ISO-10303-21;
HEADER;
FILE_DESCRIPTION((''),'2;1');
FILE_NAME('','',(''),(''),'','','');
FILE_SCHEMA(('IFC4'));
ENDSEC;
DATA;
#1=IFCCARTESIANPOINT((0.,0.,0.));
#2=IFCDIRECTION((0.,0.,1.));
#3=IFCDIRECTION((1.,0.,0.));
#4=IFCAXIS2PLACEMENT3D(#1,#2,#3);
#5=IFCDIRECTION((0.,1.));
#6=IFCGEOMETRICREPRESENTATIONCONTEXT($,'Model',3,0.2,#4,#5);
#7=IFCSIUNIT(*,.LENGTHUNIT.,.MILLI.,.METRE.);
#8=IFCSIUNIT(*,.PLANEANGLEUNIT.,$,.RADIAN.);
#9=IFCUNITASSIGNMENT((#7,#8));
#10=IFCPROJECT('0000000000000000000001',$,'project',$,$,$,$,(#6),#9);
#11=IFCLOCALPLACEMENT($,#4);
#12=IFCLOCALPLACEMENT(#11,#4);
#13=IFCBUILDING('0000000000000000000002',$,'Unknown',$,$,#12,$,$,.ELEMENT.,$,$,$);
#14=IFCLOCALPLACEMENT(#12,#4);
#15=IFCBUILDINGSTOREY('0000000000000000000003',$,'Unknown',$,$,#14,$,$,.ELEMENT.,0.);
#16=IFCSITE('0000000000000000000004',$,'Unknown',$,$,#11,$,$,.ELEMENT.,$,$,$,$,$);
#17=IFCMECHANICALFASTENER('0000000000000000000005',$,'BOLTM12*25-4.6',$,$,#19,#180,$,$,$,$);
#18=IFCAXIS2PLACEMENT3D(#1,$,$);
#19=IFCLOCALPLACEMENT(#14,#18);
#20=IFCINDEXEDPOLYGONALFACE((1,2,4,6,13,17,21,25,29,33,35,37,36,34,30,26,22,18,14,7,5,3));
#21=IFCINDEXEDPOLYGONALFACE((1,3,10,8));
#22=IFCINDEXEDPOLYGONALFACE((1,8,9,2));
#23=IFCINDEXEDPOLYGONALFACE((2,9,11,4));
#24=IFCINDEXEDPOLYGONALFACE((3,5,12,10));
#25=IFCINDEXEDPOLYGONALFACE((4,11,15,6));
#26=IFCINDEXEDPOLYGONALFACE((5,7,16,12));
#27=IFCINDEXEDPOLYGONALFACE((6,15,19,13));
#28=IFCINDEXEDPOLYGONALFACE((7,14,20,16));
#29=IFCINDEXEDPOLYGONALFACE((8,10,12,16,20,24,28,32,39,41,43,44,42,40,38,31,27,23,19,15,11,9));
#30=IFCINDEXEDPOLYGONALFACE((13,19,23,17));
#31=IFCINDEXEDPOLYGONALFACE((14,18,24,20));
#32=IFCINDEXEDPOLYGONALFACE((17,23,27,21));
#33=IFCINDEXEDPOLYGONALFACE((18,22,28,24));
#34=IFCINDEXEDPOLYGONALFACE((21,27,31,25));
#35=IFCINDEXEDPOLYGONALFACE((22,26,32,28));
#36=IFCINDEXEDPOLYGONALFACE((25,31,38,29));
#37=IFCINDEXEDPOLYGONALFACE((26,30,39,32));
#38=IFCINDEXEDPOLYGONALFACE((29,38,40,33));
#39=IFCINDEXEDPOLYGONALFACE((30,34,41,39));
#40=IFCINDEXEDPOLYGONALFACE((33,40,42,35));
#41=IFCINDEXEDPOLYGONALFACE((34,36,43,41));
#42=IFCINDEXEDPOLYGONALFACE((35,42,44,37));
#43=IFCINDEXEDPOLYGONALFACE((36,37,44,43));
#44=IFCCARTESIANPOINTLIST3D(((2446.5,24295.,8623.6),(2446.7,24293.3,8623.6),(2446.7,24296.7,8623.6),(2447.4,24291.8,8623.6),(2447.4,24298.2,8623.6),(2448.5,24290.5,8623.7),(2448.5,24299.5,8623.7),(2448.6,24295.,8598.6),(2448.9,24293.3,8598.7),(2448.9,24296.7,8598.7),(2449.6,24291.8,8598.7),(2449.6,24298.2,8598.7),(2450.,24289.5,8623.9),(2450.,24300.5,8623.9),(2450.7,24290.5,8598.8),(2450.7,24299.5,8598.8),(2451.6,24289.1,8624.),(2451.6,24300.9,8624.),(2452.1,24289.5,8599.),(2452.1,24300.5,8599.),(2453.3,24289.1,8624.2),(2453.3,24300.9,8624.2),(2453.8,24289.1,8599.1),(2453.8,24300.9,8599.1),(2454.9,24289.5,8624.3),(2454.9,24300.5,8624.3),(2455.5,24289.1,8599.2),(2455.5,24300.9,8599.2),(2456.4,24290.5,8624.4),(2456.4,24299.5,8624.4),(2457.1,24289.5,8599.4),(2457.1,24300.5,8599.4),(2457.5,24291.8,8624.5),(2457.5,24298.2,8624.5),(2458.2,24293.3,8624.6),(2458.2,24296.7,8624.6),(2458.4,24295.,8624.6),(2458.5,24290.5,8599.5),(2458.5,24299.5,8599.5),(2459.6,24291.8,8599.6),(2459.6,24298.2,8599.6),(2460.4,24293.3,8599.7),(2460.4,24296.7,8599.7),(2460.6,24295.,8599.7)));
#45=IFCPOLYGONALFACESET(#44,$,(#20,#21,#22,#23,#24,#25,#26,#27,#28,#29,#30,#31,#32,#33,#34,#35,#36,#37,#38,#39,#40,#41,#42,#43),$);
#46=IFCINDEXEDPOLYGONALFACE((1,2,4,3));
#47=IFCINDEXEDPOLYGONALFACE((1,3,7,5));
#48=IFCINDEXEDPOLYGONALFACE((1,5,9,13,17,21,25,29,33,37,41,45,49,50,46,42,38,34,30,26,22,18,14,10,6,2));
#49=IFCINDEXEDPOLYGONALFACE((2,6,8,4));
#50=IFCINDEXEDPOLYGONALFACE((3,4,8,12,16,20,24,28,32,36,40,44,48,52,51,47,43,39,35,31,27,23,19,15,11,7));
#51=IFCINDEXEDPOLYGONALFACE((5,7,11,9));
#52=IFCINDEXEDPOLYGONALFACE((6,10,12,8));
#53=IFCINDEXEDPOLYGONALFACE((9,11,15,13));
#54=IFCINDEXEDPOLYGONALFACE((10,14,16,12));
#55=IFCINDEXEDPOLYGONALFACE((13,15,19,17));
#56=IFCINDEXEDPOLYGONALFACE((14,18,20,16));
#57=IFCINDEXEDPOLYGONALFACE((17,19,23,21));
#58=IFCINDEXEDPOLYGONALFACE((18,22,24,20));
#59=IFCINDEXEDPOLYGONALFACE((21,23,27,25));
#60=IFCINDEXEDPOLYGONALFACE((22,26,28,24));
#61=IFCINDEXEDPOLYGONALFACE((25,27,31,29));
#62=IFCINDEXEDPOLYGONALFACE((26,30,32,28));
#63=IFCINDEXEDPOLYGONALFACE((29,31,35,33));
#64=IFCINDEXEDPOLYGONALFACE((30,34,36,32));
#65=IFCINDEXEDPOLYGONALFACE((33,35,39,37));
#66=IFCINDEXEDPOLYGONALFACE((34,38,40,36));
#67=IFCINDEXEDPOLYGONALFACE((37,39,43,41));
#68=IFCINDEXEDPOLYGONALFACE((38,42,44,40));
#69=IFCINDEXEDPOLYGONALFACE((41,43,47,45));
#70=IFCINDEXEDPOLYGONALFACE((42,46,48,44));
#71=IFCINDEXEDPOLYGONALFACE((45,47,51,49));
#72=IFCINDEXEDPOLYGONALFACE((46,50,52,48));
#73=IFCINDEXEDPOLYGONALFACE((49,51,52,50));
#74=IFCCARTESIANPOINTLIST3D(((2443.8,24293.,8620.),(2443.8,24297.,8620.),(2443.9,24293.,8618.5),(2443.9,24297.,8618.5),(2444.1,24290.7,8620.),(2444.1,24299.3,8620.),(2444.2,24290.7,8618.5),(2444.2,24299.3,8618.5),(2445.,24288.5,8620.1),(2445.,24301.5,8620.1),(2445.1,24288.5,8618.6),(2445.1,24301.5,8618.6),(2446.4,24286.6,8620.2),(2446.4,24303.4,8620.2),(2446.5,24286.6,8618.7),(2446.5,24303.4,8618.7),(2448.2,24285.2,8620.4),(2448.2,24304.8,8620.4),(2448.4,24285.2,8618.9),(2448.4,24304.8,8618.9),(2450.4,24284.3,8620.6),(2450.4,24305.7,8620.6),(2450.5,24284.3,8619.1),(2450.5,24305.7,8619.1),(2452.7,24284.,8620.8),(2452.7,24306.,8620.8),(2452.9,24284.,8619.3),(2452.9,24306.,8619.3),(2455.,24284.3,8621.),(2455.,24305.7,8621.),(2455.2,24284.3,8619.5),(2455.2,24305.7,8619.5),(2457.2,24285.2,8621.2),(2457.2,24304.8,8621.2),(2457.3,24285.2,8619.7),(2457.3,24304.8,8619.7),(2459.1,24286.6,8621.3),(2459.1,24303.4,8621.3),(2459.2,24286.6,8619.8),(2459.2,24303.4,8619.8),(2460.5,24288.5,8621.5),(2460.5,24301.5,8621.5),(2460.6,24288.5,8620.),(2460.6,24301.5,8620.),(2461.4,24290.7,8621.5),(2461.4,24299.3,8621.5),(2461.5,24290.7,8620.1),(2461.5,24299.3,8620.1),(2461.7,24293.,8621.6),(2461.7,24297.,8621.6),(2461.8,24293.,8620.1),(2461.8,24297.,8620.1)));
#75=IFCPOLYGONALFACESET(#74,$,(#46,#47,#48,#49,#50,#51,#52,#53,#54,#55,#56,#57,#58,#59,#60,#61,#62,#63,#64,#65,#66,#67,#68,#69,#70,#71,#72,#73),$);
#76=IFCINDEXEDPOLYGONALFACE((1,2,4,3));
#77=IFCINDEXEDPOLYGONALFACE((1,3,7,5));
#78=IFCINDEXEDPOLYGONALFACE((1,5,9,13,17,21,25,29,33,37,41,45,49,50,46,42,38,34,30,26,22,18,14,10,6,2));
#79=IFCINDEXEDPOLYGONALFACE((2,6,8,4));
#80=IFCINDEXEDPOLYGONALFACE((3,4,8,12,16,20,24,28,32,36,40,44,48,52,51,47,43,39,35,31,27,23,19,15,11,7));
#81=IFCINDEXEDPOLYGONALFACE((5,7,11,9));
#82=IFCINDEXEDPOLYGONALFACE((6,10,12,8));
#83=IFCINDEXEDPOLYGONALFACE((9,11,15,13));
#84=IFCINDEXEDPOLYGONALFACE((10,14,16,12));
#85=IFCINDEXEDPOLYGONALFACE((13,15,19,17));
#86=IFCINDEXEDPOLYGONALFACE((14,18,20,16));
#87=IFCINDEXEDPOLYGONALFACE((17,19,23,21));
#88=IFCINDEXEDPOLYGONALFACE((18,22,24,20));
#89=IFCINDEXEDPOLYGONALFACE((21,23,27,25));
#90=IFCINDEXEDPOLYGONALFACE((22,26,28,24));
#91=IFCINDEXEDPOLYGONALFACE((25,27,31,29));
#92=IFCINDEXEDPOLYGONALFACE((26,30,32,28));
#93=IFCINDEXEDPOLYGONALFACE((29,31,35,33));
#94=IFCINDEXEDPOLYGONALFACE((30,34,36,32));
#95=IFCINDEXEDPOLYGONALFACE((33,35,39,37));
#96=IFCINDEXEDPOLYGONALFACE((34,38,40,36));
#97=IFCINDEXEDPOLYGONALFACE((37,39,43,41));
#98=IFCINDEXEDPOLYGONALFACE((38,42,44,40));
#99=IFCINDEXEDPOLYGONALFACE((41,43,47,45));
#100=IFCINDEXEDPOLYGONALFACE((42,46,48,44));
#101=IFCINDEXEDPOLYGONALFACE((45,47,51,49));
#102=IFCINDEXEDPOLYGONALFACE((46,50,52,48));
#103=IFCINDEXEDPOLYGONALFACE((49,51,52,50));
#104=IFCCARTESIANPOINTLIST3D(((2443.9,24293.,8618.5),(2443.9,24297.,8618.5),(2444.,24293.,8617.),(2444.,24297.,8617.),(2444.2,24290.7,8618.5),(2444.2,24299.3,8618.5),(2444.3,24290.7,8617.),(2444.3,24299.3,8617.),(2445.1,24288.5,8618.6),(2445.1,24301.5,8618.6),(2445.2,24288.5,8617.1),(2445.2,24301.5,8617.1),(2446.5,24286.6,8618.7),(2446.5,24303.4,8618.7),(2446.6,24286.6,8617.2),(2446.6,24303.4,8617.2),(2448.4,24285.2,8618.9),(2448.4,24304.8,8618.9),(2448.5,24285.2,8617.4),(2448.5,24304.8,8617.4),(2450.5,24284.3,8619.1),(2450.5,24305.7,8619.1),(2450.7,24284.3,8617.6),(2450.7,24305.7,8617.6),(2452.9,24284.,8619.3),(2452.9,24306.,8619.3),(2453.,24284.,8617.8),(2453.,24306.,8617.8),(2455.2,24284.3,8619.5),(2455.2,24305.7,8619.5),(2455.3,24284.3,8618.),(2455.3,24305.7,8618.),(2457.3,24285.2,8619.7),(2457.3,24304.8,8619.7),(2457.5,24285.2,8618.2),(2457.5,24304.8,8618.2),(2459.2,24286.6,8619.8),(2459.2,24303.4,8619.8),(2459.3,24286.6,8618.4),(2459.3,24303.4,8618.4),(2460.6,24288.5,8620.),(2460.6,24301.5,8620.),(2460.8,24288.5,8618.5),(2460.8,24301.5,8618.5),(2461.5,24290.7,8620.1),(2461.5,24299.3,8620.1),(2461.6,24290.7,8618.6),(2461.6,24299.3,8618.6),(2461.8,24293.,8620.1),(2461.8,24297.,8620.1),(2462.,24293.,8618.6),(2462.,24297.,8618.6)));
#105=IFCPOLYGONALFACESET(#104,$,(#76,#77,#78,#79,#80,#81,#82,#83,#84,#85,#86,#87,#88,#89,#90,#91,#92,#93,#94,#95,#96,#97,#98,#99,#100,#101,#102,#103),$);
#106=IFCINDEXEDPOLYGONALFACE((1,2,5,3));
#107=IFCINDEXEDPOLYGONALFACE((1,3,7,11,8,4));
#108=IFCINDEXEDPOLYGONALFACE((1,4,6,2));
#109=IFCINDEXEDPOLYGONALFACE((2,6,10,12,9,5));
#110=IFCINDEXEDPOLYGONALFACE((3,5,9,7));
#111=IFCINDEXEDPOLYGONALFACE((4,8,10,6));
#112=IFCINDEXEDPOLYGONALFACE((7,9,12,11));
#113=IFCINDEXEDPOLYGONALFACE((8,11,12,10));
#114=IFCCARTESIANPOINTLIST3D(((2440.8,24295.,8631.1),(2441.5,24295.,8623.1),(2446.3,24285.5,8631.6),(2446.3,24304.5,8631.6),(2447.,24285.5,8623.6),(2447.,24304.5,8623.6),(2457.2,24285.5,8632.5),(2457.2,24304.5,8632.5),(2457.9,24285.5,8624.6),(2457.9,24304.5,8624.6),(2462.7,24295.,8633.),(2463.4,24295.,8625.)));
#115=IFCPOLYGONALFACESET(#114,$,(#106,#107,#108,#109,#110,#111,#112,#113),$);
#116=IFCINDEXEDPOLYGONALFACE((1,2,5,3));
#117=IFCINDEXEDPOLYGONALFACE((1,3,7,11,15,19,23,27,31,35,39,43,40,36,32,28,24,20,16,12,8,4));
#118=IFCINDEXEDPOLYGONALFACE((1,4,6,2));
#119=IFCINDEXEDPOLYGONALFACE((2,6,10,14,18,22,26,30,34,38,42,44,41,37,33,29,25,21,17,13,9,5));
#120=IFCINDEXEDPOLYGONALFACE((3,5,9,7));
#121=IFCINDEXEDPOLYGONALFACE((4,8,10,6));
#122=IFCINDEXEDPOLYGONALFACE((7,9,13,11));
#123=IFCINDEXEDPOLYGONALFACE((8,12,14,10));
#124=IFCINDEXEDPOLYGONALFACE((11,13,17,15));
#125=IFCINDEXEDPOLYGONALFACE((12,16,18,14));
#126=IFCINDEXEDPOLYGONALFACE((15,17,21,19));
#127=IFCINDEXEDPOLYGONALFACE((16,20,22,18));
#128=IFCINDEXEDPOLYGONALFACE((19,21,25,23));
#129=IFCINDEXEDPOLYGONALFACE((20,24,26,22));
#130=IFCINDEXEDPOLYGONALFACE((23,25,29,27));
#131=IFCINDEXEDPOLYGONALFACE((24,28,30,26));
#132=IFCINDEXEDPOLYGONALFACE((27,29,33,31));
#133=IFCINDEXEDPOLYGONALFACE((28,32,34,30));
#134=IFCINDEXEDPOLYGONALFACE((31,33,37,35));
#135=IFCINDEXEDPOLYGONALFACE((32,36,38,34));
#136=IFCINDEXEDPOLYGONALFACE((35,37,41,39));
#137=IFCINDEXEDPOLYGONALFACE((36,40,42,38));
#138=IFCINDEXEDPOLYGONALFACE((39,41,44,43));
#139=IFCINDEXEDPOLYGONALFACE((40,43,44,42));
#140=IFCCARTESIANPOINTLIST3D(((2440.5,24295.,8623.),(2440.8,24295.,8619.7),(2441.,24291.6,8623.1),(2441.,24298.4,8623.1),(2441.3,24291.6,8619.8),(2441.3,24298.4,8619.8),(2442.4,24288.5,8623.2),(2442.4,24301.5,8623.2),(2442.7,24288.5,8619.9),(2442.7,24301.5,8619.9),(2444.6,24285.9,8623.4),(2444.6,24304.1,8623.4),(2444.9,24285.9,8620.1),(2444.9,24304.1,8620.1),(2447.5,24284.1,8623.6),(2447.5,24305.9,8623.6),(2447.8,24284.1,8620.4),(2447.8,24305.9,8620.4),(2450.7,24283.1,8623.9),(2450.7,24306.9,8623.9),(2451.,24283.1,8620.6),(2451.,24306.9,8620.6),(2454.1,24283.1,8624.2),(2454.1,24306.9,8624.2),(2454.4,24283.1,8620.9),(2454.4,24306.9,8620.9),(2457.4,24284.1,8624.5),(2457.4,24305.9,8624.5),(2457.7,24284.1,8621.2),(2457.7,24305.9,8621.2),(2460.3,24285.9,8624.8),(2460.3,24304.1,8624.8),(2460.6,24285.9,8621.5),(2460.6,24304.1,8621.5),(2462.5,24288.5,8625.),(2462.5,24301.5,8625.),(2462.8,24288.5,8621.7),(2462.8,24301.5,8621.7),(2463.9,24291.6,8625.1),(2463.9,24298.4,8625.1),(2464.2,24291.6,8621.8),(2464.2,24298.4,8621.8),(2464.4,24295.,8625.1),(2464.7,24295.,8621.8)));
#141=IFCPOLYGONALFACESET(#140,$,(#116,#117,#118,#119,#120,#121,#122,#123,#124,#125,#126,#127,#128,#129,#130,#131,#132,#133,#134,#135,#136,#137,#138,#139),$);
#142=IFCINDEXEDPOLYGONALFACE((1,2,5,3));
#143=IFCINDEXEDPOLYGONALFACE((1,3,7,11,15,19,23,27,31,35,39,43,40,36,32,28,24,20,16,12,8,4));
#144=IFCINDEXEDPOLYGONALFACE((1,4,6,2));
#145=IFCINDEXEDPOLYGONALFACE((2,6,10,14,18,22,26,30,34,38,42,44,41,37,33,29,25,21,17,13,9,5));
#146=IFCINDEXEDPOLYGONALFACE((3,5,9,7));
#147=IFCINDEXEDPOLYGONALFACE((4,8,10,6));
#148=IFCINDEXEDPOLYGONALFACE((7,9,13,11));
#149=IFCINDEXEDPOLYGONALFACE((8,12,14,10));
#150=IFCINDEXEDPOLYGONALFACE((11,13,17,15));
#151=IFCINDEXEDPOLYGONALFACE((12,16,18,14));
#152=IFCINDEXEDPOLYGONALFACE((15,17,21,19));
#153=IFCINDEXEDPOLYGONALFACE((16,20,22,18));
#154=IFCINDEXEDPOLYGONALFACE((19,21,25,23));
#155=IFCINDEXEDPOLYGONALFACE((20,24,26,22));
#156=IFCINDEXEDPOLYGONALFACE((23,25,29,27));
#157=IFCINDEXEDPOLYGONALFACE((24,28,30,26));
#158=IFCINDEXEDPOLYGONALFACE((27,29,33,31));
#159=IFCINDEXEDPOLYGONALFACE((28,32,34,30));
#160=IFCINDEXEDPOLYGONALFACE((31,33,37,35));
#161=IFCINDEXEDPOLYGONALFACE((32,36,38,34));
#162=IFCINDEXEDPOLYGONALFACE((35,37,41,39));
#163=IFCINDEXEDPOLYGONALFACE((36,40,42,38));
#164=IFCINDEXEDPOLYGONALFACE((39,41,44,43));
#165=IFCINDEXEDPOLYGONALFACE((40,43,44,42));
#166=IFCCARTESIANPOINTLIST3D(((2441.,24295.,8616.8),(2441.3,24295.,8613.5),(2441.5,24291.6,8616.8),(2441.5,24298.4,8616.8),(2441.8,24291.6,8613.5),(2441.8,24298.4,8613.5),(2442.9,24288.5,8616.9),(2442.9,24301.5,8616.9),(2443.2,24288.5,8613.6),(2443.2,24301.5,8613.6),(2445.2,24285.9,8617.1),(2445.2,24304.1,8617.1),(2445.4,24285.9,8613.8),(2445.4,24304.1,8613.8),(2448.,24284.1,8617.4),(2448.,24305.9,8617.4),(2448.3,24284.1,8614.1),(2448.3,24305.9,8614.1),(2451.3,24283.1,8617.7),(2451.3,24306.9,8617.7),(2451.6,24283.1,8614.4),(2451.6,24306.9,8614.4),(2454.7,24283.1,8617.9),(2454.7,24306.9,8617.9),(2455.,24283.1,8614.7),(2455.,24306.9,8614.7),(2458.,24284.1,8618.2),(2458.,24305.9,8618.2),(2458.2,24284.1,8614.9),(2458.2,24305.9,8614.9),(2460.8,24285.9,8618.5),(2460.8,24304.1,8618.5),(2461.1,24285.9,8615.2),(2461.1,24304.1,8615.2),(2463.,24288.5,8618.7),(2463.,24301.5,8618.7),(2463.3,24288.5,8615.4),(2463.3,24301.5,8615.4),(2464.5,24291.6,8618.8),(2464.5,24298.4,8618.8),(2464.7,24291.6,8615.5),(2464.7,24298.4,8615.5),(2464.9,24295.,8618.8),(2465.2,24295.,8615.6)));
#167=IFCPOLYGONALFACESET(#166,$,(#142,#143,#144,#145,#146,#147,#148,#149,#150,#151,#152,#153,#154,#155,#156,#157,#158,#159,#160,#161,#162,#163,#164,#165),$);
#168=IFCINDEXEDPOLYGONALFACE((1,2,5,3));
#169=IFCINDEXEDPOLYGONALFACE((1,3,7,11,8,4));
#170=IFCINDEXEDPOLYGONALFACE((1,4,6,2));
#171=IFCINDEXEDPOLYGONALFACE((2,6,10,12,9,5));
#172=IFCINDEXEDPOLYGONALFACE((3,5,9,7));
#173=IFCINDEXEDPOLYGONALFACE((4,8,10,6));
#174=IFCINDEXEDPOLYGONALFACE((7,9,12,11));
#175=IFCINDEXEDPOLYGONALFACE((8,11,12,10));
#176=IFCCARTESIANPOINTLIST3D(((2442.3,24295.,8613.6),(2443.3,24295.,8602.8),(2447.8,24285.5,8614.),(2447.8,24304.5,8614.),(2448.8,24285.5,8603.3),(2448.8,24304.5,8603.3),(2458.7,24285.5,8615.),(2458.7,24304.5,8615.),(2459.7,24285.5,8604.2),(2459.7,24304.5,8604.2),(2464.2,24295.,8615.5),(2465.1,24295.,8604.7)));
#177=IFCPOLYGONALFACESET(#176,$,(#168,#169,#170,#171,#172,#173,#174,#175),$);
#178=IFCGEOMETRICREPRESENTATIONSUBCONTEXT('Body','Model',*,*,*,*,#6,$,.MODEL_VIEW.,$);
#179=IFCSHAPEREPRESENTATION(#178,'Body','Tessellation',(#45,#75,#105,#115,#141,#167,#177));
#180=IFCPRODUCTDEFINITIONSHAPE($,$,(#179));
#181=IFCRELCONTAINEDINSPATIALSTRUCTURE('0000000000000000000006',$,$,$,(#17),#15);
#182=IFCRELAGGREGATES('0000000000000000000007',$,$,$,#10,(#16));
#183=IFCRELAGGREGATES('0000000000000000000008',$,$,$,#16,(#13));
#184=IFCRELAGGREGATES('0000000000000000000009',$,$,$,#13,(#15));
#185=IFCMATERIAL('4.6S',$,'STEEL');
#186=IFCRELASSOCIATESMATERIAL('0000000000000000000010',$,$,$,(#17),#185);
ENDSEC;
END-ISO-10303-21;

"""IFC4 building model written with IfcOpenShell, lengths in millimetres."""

from ifc_helpers import new_model, si_unit, direction, frame, origin_with_axes, place, context, subcontext, project, spatial, line, arc, indexed_curve, outline, extrude, source, transform, mapped, material, element, save


model = new_model("IFC4")

# Units and contexts
model_context = context("Model", 3, precision=0.2, world=origin_with_axes(), true_north=direction((0.0, 1.0)))
body_context = subcontext(model_context, "Body", "Model", "MODEL_VIEW")
ifc_project = project(units=[si_unit("LENGTHUNIT", "METRE", prefix="MILLI"), si_unit("PLANEANGLEUNIT", "RADIAN")], contexts=[model_context])

# Site, building, storey
site_placement = place(None, origin_with_axes())
site = spatial("IfcSite", under=ifc_project, at=site_placement, Name="Unknown", CompositionType="ELEMENT")
building_placement = place(site_placement, origin_with_axes())
building = spatial("IfcBuilding", under=site, at=building_placement, Name="Unknown", CompositionType="ELEMENT")
storey_placement = place(building_placement, origin_with_axes())
storey = spatial("IfcBuildingStorey", under=building, at=storey_placement, Name="Unknown", CompositionType="ELEMENT", Elevation=0.0)

# Mechanical fastener
ifc_material_1 = material(Name="4.6S", Category="STEEL")
shared_shape_1 = source(origin_with_axes(), body_context, "Body", "SweptSolid", [
    extrude(outline(indexed_curve([(6.0, 0.0), (0.0, 6.0), (-6.0, 0.0), (0.0, -6.0)], segments=[arc(1, 2, 3), arc(3, 4, 1)])), frame((0.0, 0.0, 4.8), z_axis=(0.0, 0.0, -1.0), x_axis=(0.0, 1.0, 0.0)), (0.0, 0.0, 1.0), 25.0),
    extrude(outline(indexed_curve([(0.0, 11.0), (6.4, 8.4), (9.0, 2.0), (9.0, -2.0), (6.4, -8.4), (0.0, -11.0), (-0.8, -11.0), (-9.0, -2.0), (-9.0, 2.0), (-6.4, 8.4)], segments=[arc(1, 2, 3), line(3, 4), arc(4, 5, 6), arc(6, 7, 8), line(8, 9), arc(9, 10, 1)])), frame((0.0, 0.0, 1.5), z_axis=(0.0, 0.0, -1.0), x_axis=(0.0, 1.0, 0.0)), (0.0, 0.0, 1.0), 1.5),
    extrude(outline(indexed_curve([(0.0, 11.0), (6.4, 8.4), (9.0, 2.0), (9.0, -2.0), (6.4, -8.4), (0.0, -11.0), (-0.8, -11.0), (-9.0, -2.0), (-9.0, 2.0), (-6.4, 8.4)], segments=[arc(1, 2, 3), line(3, 4), arc(4, 5, 6), arc(6, 7, 8), line(8, 9), arc(9, 10, 1)])), frame((0.0, 0.0, 0.0), z_axis=(0.0, 0.0, -1.0), x_axis=(0.0, 1.0, 0.0)), (0.0, 0.0, 1.0), 1.5),
    extrude(outline(indexed_curve([(11.0, 0.0), (5.5, 9.5), (-5.5, 9.5), (-11.0, 0.0), (-5.5, -9.5), (5.5, -9.5)], segments=[line(1, 2, 3, 4, 5, 6, 1)])), frame((0.0, 0.0, 12.8), z_axis=(0.0, 0.0, -1.0), x_axis=(0.0, 1.0, 0.0)), (0.0, 0.0, 1.0), 8.0),
    extrude(outline(indexed_curve([(12.0, 0.0), (0.0, 12.0), (-12.0, 0.0), (0.0, -12.0)], segments=[arc(1, 2, 3), arc(3, 4, 1)])), frame((0.0, 0.0, 4.8), z_axis=(0.0, 0.0, -1.0), x_axis=(0.0, 1.0, 0.0)), (0.0, 0.0, 1.0), 3.3),
    extrude(outline(indexed_curve([(12.0, 0.0), (0.0, 12.0), (-12.0, 0.0), (0.0, -12.0)], segments=[arc(1, 2, 3), arc(3, 4, 1)])), frame((0.0, 0.0, -1.5), z_axis=(0.0, 0.0, -1.0), x_axis=(0.0, 1.0, 0.0)), (0.0, 0.0, 1.0), 3.3),
    extrude(outline(indexed_curve([(11.0, 0.0), (5.5, 9.5), (-5.5, 9.5), (-11.0, 0.0), (-5.5, -9.5), (5.5, -9.5)], segments=[line(1, 2, 3, 4, 5, 6, 1)])), frame((0.0, 0.0, -4.8), z_axis=(0.0, 0.0, -1.0), x_axis=(0.0, 1.0, 0.0)), (0.0, 0.0, 1.0), 10.8),
])
for number, where, z_axis, x_axis, name in (
    (1, (2452.9, 24295.0, 8619.3), (-0.08716, 0.0, 0.996194), (0.0, 1.0, 0.0), "BOLTM12*25-4.6"),
):
    element("IfcMechanicalFastener", number, at=place(storey_placement, frame(where, z_axis=z_axis, x_axis=x_axis)), inside=storey, material=ifc_material_1, Name=name, context=body_context, shape_type="MappedRepresentation", body=[
        mapped(shared_shape_1, transform((0.0, 0.0, 0.0))),
    ])

save(model, "model.ifc")
